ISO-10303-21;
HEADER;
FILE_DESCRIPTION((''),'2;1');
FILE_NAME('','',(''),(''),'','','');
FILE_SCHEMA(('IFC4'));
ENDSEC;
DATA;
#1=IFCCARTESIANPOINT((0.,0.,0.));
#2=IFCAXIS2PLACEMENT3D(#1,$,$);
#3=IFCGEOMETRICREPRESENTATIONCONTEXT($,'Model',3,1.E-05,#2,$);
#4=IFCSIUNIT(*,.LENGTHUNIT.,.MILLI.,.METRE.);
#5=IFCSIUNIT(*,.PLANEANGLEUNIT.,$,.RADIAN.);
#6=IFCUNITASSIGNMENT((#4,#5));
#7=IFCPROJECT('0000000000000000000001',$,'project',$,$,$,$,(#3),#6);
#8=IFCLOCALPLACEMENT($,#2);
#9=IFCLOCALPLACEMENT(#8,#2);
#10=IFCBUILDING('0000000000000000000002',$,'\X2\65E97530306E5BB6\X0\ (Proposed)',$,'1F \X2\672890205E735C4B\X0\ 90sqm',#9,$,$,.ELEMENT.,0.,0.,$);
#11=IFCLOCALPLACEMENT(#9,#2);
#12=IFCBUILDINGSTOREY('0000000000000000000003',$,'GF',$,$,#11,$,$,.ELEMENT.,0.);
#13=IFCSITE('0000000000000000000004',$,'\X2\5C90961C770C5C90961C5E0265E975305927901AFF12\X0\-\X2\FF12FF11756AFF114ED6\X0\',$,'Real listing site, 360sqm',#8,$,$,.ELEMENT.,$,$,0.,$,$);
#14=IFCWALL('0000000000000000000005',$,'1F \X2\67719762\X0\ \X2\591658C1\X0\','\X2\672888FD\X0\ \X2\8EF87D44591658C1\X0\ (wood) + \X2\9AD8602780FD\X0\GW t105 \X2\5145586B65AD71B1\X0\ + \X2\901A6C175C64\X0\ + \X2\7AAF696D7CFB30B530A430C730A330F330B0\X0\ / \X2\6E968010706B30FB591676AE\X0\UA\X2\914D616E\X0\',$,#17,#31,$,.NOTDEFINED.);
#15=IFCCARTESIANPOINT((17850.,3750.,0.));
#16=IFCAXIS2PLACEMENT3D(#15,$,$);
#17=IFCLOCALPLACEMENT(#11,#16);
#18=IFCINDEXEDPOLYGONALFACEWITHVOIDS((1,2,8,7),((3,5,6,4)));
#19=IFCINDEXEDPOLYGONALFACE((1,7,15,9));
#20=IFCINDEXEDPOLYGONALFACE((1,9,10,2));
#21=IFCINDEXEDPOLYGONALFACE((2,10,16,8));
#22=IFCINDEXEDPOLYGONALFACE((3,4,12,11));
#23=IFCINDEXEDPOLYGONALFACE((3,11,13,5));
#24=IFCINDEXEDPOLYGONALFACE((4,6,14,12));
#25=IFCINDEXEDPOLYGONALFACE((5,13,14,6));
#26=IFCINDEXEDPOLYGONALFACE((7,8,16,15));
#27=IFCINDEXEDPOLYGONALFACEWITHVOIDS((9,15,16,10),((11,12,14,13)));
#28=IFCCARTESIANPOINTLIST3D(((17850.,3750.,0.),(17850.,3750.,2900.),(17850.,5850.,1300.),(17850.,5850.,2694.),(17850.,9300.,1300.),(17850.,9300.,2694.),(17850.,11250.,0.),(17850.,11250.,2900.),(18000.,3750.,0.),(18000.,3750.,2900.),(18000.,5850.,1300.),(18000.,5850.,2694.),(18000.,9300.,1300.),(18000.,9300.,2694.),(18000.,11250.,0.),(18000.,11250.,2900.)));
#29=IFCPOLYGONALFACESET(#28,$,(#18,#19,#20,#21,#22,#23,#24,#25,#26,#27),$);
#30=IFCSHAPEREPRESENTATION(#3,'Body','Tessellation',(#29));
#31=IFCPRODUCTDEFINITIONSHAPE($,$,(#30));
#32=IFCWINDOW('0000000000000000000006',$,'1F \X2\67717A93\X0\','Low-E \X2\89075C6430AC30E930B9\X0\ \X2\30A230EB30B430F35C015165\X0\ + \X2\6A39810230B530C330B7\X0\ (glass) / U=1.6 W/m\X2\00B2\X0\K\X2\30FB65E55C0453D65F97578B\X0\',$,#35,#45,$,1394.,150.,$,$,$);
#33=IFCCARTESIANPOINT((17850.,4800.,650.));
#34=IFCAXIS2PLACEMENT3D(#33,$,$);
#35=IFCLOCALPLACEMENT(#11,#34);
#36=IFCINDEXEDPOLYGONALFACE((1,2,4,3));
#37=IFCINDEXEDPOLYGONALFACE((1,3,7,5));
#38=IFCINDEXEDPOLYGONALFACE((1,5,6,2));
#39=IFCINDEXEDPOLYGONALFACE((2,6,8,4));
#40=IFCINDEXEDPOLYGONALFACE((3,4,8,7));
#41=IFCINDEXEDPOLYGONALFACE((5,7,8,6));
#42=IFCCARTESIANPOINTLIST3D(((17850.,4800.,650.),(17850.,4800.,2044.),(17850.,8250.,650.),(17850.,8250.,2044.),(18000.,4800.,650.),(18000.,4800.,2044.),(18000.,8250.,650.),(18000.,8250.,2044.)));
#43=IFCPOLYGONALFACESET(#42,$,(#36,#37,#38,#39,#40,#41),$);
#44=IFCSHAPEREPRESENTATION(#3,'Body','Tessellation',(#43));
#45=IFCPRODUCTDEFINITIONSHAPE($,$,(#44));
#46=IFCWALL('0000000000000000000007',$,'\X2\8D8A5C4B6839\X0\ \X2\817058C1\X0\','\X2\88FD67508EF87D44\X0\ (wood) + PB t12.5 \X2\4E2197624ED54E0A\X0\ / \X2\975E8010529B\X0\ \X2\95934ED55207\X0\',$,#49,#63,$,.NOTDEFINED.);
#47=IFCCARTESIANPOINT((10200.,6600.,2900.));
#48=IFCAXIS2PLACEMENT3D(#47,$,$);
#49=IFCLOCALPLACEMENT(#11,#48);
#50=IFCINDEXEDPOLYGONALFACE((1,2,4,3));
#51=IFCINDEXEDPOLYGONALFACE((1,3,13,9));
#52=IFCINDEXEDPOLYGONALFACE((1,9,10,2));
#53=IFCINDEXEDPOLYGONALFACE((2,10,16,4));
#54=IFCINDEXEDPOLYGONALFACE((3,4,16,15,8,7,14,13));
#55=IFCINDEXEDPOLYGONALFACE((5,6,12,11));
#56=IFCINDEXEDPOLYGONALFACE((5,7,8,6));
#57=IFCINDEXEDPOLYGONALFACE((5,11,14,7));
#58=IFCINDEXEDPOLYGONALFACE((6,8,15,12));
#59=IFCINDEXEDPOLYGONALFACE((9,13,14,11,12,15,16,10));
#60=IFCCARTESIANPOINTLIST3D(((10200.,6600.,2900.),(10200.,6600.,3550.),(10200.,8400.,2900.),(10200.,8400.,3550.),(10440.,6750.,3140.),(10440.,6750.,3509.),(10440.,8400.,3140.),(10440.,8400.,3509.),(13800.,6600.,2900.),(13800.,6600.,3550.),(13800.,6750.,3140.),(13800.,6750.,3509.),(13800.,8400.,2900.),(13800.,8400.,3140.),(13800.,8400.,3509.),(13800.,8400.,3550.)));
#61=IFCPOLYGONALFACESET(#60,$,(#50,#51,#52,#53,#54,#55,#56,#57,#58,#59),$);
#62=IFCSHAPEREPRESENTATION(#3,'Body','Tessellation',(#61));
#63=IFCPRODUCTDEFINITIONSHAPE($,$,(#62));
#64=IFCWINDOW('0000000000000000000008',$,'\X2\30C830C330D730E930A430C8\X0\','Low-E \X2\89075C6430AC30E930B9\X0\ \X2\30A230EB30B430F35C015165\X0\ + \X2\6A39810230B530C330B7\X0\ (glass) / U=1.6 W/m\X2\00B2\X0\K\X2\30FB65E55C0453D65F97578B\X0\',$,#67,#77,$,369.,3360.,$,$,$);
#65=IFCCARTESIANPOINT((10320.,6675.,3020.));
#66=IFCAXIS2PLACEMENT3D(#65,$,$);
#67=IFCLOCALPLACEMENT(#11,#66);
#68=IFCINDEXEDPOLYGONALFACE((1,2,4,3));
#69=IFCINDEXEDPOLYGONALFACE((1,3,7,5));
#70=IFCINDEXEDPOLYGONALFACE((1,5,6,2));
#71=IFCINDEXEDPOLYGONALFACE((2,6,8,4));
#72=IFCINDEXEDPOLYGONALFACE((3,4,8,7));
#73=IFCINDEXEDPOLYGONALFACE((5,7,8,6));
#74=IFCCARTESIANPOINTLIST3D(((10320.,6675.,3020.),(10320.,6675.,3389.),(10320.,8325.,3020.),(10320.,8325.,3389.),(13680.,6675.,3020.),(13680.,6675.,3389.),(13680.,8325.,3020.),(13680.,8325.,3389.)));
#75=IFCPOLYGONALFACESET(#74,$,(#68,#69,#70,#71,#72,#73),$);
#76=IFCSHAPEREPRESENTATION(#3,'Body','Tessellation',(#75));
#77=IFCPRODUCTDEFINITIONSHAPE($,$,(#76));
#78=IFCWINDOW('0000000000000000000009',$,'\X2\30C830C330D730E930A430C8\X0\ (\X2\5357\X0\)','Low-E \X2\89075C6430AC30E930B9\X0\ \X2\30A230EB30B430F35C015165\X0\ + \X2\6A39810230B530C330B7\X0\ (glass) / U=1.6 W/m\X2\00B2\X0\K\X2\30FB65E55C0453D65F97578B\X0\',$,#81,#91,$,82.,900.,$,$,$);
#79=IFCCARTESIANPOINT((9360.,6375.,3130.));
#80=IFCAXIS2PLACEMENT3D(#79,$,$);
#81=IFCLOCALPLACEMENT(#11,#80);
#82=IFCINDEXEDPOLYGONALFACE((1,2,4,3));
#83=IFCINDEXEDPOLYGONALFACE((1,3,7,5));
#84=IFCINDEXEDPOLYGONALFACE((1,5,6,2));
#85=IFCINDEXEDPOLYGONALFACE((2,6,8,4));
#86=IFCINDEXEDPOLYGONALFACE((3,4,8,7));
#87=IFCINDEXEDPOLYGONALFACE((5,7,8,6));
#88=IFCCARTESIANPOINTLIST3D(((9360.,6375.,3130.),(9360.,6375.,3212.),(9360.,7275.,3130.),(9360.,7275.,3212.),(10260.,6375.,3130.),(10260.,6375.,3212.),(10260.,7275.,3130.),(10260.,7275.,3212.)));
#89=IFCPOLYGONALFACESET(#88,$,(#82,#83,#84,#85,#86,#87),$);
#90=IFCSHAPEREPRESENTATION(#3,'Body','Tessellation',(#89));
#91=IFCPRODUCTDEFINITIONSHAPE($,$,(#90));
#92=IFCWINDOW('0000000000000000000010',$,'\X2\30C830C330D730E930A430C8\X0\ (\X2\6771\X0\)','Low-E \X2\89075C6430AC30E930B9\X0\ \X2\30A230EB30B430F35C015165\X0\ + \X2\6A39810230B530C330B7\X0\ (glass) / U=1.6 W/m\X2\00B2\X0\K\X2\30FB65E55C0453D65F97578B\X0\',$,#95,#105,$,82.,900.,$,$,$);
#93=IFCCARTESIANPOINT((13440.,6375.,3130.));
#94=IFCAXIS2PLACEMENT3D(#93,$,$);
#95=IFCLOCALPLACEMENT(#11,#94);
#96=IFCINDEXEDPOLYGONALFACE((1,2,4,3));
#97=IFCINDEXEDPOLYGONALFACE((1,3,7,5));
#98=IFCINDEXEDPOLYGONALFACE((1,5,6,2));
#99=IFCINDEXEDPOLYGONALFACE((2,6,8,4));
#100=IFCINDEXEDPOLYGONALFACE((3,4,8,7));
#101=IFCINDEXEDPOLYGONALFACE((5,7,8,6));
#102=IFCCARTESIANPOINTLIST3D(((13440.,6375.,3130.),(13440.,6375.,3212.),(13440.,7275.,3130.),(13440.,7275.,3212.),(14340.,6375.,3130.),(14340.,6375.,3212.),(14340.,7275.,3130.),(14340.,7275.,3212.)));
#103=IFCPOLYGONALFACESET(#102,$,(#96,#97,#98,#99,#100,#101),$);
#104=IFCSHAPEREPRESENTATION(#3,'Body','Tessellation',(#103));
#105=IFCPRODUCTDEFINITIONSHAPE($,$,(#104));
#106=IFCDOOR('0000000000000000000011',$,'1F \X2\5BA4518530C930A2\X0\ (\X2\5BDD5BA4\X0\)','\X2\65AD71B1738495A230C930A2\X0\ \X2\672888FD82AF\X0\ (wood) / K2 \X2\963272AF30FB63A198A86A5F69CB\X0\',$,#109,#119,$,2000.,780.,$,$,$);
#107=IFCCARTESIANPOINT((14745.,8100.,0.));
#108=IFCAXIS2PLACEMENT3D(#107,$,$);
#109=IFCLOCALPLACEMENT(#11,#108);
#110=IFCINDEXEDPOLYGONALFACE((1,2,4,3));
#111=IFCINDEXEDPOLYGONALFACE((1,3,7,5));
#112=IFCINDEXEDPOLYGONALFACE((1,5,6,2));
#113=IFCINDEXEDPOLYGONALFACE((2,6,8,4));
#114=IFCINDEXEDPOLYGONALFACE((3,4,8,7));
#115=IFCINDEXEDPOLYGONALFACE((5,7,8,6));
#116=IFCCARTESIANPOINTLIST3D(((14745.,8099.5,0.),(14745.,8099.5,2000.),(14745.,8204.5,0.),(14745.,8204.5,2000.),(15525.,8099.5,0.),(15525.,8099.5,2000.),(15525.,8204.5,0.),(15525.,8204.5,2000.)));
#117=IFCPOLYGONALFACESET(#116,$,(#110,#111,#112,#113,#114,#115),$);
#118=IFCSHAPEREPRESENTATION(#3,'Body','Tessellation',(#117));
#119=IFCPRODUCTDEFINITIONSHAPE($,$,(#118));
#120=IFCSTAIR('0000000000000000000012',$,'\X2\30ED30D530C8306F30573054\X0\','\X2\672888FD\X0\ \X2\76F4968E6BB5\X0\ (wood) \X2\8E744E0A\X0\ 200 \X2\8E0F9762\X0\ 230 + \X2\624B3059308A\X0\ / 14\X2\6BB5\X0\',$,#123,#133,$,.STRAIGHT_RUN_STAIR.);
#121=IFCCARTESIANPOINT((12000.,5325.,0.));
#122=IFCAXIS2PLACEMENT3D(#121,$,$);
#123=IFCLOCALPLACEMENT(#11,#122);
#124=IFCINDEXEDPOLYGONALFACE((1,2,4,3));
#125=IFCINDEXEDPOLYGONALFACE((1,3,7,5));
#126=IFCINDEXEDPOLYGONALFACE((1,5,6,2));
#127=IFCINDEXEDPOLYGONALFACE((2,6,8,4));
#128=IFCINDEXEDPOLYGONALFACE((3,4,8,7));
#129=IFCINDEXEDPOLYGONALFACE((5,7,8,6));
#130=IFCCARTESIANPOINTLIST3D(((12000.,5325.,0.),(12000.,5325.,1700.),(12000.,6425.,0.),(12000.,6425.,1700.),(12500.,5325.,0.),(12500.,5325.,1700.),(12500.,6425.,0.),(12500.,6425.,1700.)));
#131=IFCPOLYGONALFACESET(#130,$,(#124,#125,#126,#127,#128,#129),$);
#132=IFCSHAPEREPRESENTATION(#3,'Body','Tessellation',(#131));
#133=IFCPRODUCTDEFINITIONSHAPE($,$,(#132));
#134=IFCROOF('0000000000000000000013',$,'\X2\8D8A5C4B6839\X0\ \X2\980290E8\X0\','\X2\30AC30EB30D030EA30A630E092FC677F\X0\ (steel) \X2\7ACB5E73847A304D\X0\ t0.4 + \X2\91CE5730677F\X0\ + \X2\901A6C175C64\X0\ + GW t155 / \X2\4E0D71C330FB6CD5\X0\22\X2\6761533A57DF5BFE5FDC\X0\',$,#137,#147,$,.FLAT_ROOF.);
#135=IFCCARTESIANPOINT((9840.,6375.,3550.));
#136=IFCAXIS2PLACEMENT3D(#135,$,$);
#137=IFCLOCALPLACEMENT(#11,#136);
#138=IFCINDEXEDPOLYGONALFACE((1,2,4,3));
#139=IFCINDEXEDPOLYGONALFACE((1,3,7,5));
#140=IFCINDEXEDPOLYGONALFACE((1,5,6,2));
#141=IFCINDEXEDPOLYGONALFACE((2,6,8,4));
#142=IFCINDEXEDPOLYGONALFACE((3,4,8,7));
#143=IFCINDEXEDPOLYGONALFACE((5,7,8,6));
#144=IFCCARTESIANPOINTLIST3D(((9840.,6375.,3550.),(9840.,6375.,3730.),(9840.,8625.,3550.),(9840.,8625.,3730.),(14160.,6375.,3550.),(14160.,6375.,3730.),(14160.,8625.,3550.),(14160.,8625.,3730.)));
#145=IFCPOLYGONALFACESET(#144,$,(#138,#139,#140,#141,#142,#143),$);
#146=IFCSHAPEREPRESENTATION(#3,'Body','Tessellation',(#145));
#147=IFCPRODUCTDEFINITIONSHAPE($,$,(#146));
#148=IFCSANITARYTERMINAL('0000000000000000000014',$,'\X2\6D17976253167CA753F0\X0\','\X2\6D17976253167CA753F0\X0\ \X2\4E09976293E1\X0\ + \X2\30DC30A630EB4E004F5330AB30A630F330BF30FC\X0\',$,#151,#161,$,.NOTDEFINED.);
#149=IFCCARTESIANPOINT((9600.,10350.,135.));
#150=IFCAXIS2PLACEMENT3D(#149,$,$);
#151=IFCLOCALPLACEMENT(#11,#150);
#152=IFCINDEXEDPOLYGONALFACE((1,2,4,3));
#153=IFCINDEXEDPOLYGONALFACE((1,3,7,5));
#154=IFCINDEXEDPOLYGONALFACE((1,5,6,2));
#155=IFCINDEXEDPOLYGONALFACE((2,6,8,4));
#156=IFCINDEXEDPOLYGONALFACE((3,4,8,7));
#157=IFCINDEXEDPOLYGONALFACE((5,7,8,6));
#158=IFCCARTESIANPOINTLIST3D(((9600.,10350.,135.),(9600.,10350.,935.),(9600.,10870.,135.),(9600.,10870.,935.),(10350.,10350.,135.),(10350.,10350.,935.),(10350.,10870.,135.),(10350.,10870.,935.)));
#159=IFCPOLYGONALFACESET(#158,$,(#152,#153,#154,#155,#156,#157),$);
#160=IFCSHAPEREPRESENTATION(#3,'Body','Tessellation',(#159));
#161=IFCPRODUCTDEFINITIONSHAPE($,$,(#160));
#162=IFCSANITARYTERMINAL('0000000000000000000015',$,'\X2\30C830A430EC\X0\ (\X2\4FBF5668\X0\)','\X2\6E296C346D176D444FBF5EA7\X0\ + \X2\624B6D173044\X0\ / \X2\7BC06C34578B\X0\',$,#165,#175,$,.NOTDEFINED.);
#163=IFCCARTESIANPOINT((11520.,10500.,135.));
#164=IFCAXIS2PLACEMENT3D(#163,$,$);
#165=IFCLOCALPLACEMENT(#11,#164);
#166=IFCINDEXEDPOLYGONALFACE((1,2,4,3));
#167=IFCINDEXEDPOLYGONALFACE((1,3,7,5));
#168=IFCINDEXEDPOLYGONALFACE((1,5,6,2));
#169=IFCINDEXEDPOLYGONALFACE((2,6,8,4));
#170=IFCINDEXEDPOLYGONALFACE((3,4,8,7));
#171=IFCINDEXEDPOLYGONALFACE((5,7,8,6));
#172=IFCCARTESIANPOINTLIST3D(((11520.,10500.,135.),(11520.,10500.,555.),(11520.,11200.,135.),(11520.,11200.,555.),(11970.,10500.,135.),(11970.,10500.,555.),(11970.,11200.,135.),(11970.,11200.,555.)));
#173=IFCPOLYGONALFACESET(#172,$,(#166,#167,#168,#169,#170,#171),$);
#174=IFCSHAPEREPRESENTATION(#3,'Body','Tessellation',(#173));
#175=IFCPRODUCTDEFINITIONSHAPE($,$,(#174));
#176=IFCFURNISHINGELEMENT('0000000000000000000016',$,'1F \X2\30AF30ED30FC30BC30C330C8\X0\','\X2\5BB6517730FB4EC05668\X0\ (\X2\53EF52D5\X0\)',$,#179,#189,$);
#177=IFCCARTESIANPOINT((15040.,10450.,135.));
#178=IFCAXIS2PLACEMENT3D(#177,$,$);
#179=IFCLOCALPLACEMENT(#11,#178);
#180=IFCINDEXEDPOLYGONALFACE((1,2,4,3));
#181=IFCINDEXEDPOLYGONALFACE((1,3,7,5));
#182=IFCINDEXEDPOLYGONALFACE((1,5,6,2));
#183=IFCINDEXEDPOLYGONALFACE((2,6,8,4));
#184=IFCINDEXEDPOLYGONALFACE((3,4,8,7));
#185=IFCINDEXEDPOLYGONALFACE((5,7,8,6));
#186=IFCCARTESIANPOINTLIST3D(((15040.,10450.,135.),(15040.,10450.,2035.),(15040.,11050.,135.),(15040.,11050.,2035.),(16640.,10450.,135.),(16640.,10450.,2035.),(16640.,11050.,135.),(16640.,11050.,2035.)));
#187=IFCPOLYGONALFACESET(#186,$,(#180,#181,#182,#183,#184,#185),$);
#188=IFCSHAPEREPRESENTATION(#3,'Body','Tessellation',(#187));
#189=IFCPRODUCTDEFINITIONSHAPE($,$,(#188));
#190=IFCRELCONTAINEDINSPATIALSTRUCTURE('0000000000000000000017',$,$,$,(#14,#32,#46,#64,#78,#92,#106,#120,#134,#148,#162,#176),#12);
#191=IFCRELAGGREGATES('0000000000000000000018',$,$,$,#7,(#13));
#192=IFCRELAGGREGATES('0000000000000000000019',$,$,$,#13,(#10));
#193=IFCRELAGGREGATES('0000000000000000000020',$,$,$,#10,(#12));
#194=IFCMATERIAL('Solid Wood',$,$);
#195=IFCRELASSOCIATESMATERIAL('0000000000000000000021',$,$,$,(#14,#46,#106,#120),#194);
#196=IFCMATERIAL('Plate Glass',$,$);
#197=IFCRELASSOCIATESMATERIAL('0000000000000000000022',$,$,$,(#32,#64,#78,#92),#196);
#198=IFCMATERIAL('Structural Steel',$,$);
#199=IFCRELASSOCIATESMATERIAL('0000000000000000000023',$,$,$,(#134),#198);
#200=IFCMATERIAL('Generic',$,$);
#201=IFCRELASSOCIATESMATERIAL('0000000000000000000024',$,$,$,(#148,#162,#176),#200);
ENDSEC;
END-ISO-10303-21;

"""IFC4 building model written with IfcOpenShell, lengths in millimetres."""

from ifc_helpers import new_model, si_unit, frame, frame_2d, origin, place, context, project, spatial, rectangle, extrude, material, element, fill, save


model = new_model("IFC4")

# Units and contexts
model_context = context("Model", 3, precision=1e-05, world=origin())
ifc_project = project(units=[si_unit("LENGTHUNIT", "METRE", prefix="MILLI"), si_unit("PLANEANGLEUNIT", "RADIAN")], contexts=[model_context])

# Site, building, storey
site_placement = place(None, origin())
site = spatial("IfcSite", under=ifc_project, at=site_placement, Name="岐阜県岐阜市早田大通２-２１番１他", ObjectType="Real listing site, 360sqm", CompositionType="ELEMENT", RefElevation=0.0)
building_placement = place(site_placement, origin())
building = spatial("IfcBuilding", under=site, at=building_placement, Name="早田の家 (Proposed)", ObjectType="1F 木造平屋 90sqm", CompositionType="ELEMENT", ElevationOfRefHeight=0.0, ElevationOfTerrain=0.0)
storey_placement = place(building_placement, origin())
storey = spatial("IfcBuildingStorey", under=building, at=storey_placement, Name="GF", CompositionType="ELEMENT", Elevation=0.0)

# Wall, opening, window
ifc_material_1 = material(Name="Solid Wood")
wall_1_placement = place(storey_placement, frame((17850.0, 3750.0, 0.0)))
wall_1 = element("IfcWall", 1, at=wall_1_placement, inside=storey, material=ifc_material_1, Name="1F 東面 外壁", Description="木製 軸組外壁 (wood) + 高性能GW t105 充填断熱 + 通気層 + 窯業系サイディング / 準耐火・外皮UA配慮", PredefinedType="NOTDEFINED", context=model_context, shape_type="SweptSolid", body=[
    extrude(rectangle(XDim=150.0, YDim=7500.0, at=frame_2d((75.0, 3750.0))), frame((17850.0, 3750.0, 0.0)), (0.0, 0.0, 1.0), 2900.0),
])
opening_1_placement = place(storey_placement, frame((17850.0, 4800.0, 650.0)))
opening_1 = element("IfcOpeningElement", 2, at=opening_1_placement, cuts=wall_1, PredefinedType="NOTDEFINED", context=model_context, shape_type="SweptSolid", body=[
    extrude(rectangle(XDim=150.0, YDim=3450.0, at=frame_2d((75.0, 1725.0))), frame((17850.0, 4800.0, 650.0)), (0.0, 0.0, 1.0), 1394.0),
])
ifc_material_2 = material(Name="Plate Glass")
window_1_placement = place(storey_placement, frame((17850.0, 4800.0, 650.0)))
window_1 = element("IfcWindow", 3, at=window_1_placement, inside=storey, material=ifc_material_2, Name="1F 東窓", Description="Low-E 複層ガラス アルゴン封入 + 樹脂サッシ (glass) / U=1.6 W/m²K・日射取得型", OverallHeight=1394.0, OverallWidth=150.0, context=model_context, shape_type="SweptSolid", body=[
    extrude(rectangle(XDim=150.0, YDim=3450.0, at=frame_2d((75.0, 1725.0))), frame((17850.0, 4800.0, 650.0)), (0.0, 0.0, 1.0), 1394.0),
])
fill(opening_1, window_1)

# Wall, openings, windows
wall_2_placement = place(storey_placement, frame((10200.0, 6600.0, 2900.0)))
wall_2 = element("IfcWall", 4, at=wall_2_placement, inside=storey, material=ifc_material_1, Name="越屋根 腰壁", Description="製材軸組 (wood) + PB t12.5 両面仕上 / 非耐力 間仕切", PredefinedType="NOTDEFINED", context=model_context, shape_type="SweptSolid", body=[
    extrude(rectangle(XDim=3600.0, YDim=1800.0, at=frame_2d((1800.0, 900.0))), frame((10200.0, 6600.0, 2900.0)), (0.0, 0.0, 1.0), 650.0),
])
opening_2_placement = place(storey_placement, frame((10320.0, 6675.0, 3020.0)))
opening_2 = element("IfcOpeningElement", 5, at=opening_2_placement, cuts=wall_2, PredefinedType="NOTDEFINED", context=model_context, shape_type="SweptSolid", body=[
    extrude(rectangle(XDim=3360.0, YDim=1650.0, at=frame_2d((1680.0, 825.0))), frame((10320.0, 6675.0, 3020.0)), (0.0, 0.0, 1.0), 369.0),
])
opening_3_placement = place(storey_placement, frame((9360.0, 6375.0, 3130.0)))
opening_3 = element("IfcOpeningElement", 6, at=opening_3_placement, cuts=wall_2, PredefinedType="NOTDEFINED", context=model_context, shape_type="SweptSolid", body=[
    extrude(rectangle(XDim=900.0, YDim=900.0, at=frame_2d((450.0, 450.0))), frame((9360.0, 6375.0, 3130.0)), (0.0, 0.0, 1.0), 82.0),
])
opening_4_placement = place(storey_placement, frame((13440.0, 6375.0, 3130.0)))
opening_4 = element("IfcOpeningElement", 7, at=opening_4_placement, cuts=wall_2, PredefinedType="NOTDEFINED", context=model_context, shape_type="SweptSolid", body=[
    extrude(rectangle(XDim=900.0, YDim=900.0, at=frame_2d((450.0, 450.0))), frame((13440.0, 6375.0, 3130.0)), (0.0, 0.0, 1.0), 82.0),
])
window_2_placement = place(storey_placement, frame((10320.0, 6675.0, 3020.0)))
window_2 = element("IfcWindow", 8, at=window_2_placement, inside=storey, material=ifc_material_2, Name="トップライト", Description="Low-E 複層ガラス アルゴン封入 + 樹脂サッシ (glass) / U=1.6 W/m²K・日射取得型", OverallHeight=369.0, OverallWidth=3360.0, context=model_context, shape_type="SweptSolid", body=[
    extrude(rectangle(XDim=3360.0, YDim=1650.0, at=frame_2d((1680.0, 825.0))), frame((10320.0, 6675.0, 3020.0)), (0.0, 0.0, 1.0), 369.0),
])
fill(opening_2, window_2)
window_3_placement = place(storey_placement, frame((9360.0, 6375.0, 3130.0)))
window_3 = element("IfcWindow", 9, at=window_3_placement, inside=storey, material=ifc_material_2, Name="トップライト (南)", Description="Low-E 複層ガラス アルゴン封入 + 樹脂サッシ (glass) / U=1.6 W/m²K・日射取得型", OverallHeight=82.0, OverallWidth=900.0, context=model_context, shape_type="SweptSolid", body=[
    extrude(rectangle(XDim=900.0, YDim=900.0, at=frame_2d((450.0, 450.0))), frame((9360.0, 6375.0, 3130.0)), (0.0, 0.0, 1.0), 82.0),
])
fill(opening_3, window_3)
window_4_placement = place(storey_placement, frame((13440.0, 6375.0, 3130.0)))
window_4 = element("IfcWindow", 10, at=window_4_placement, inside=storey, material=ifc_material_2, Name="トップライト (東)", Description="Low-E 複層ガラス アルゴン封入 + 樹脂サッシ (glass) / U=1.6 W/m²K・日射取得型", OverallHeight=82.0, OverallWidth=900.0, context=model_context, shape_type="SweptSolid", body=[
    extrude(rectangle(XDim=900.0, YDim=900.0, at=frame_2d((450.0, 450.0))), frame((13440.0, 6375.0, 3130.0)), (0.0, 0.0, 1.0), 82.0),
])
fill(opening_4, window_4)

# Door
door_placement = place(storey_placement, frame((14745.0, 8100.0, 0.0)))
element("IfcDoor", 11, at=door_placement, inside=storey, material=ifc_material_1, Name="1F 室内ドア (寝室)", Description="断熱玄関ドア 木製芯 (wood) / K2 防犯・採風機構", OverallHeight=2000.0, OverallWidth=780.0, context=model_context, shape_type="SweptSolid", body=[
    extrude(rectangle(XDim=780.0, YDim=105.0, at=frame_2d((390.0, 52.0))), frame((14745.0, 8100.0, 0.0)), (0.0, 0.0, 1.0), 2000.0),
])

# Stair
stair_placement = place(storey_placement, frame((12000.0, 5325.0, 0.0)))
element("IfcStair", 12, at=stair_placement, inside=storey, material=ifc_material_1, Name="ロフトはしご", Description="木製 直階段 (wood) 蹴上 200 踏面 230 + 手すり / 14段", PredefinedType="STRAIGHT_RUN_STAIR", context=model_context, shape_type="SweptSolid", body=[
    extrude(rectangle(XDim=500.0, YDim=1100.0, at=frame_2d((250.0, 550.0))), frame((12000.0, 5325.0, 0.0)), (0.0, 0.0, 1.0), 1700.0),
])

# Roof
ifc_material_3 = material(Name="Structural Steel")
roof_placement = place(storey_placement, frame((9840.0, 6375.0, 3550.0)))
element("IfcRoof", 13, at=roof_placement, inside=storey, material=ifc_material_3, Name="越屋根 頂部", Description="ガルバリウム鋼板 (steel) 立平葺き t0.4 + 野地板 + 通気層 + GW t155 / 不燃・法22条区域対応", PredefinedType="FLAT_ROOF", context=model_context, shape_type="SweptSolid", body=[
    extrude(rectangle(XDim=4320.0, YDim=2250.0, at=frame_2d((2160.0, 1125.0))), frame((9840.0, 6375.0, 3550.0)), (0.0, 0.0, 1.0), 180.0),
])

# Sanitary terminals
ifc_material_4 = material(Name="Generic")
sanitary_terminal_1_placement = place(storey_placement, frame((9600.0, 10350.0, 135.0)))
element("IfcSanitaryTerminal", 14, at=sanitary_terminal_1_placement, inside=storey, material=ifc_material_4, Name="洗面化粧台", Description="洗面化粧台 三面鏡 + ボウル一体カウンター", PredefinedType="NOTDEFINED", context=model_context, shape_type="SweptSolid", body=[
    extrude(rectangle(XDim=750.0, YDim=520.0, at=frame_2d((375.0, 260.0))), frame((9600.0, 10350.0, 135.0)), (0.0, 0.0, 1.0), 800.0),
])
sanitary_terminal_2_placement = place(storey_placement, frame((11520.0, 10500.0, 135.0)))
element("IfcSanitaryTerminal", 15, at=sanitary_terminal_2_placement, inside=storey, material=ifc_material_4, Name="トイレ (便器)", Description="温水洗浄便座 + 手洗い / 節水型", PredefinedType="NOTDEFINED", context=model_context, shape_type="SweptSolid", body=[
    extrude(rectangle(XDim=450.0, YDim=700.0, at=frame_2d((225.0, 350.0))), frame((11520.0, 10500.0, 135.0)), (0.0, 0.0, 1.0), 420.0),
])

# Furnishing element
furnishing_1_placement = place(storey_placement, frame((15040.0, 10450.0, 135.0)))
element("IfcFurnishingElement", 16, at=furnishing_1_placement, inside=storey, material=ifc_material_4, Name="1F クローゼット", Description="家具・什器 (可動)", context=model_context, shape_type="SweptSolid", body=[
    extrude(rectangle(XDim=1600.0, YDim=600.0, at=frame_2d((800.0, 300.0))), frame((15040.0, 10450.0, 135.0)), (0.0, 0.0, 1.0), 1900.0),
])

save(model, "model.ifc")
